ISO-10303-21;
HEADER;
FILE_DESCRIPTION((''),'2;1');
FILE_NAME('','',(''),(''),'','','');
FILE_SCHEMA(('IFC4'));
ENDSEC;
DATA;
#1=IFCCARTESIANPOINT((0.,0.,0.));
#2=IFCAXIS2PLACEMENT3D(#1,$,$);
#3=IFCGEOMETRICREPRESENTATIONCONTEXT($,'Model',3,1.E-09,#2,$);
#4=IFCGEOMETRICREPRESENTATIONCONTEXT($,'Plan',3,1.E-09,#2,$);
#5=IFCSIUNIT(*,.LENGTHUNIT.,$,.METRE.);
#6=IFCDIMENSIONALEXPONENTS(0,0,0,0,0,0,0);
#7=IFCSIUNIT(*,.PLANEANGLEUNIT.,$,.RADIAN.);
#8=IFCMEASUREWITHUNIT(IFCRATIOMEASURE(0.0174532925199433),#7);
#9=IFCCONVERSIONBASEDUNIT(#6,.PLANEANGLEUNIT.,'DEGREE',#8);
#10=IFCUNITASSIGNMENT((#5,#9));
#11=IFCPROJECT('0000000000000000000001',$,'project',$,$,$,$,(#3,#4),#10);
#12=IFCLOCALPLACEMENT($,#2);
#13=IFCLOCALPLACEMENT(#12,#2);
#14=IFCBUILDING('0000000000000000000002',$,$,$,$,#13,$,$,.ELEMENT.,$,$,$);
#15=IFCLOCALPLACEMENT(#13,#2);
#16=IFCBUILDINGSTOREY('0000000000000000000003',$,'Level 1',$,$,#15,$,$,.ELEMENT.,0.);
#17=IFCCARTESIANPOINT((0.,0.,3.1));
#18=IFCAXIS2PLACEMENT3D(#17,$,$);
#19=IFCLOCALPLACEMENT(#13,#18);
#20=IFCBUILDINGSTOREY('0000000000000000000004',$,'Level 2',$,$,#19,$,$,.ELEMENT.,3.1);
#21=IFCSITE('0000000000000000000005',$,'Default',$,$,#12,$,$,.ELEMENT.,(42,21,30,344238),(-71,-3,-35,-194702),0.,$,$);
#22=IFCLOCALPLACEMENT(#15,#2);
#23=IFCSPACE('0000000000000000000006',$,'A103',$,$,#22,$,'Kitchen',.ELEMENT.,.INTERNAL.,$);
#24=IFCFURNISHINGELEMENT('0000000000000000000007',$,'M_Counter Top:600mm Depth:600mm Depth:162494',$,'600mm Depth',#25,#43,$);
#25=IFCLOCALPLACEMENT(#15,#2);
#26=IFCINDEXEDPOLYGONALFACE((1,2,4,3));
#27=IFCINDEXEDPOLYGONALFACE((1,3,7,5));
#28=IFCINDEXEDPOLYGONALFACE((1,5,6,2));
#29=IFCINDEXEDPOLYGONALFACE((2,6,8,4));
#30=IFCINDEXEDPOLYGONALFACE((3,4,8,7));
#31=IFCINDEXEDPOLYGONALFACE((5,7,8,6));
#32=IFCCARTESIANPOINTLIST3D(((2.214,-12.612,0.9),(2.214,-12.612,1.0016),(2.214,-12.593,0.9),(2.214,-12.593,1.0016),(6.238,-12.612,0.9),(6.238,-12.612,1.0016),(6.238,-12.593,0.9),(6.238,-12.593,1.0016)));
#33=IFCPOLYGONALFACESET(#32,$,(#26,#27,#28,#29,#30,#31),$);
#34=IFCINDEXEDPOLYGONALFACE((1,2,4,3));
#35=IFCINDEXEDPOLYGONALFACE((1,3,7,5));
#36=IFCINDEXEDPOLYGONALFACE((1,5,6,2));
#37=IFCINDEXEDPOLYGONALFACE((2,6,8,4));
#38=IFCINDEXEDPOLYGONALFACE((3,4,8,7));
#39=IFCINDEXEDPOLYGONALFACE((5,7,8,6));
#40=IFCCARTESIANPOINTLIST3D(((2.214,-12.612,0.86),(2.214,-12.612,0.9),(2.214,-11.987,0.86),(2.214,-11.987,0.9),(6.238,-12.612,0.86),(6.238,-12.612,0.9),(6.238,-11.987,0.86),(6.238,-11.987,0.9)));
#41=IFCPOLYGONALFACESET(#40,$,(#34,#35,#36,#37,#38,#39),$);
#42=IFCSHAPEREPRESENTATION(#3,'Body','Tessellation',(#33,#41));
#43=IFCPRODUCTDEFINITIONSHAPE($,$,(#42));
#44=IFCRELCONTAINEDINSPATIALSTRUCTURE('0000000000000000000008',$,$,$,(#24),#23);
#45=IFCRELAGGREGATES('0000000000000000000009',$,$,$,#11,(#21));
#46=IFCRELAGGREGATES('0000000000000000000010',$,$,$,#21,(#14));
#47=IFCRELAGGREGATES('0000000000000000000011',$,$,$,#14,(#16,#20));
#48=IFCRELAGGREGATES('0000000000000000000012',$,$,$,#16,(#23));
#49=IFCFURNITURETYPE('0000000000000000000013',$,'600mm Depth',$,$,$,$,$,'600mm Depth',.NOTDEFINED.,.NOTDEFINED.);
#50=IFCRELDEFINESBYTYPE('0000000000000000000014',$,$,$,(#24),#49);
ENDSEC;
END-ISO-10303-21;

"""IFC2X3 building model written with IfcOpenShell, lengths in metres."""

from ifc_helpers import new_model, entity, si_unit, converted_unit, frame, origin, origin_2d_with_axis, place, context, project, spatial, rectangle, extrude, source, transform, mapped, type_object, type_shapes, element, save


model = new_model("IFC2X3")

# Units and contexts
model_context = context("Model", 3, precision=1e-09, world=origin())
plan_context = context("Plan", 3, precision=1e-09, world=origin())
ifc_project = project(units=[si_unit("LENGTHUNIT", "METRE"), converted_unit("PLANEANGLEUNIT", "DEGREE", entity("IfcRatioMeasure", 0.0174532925199433), si_unit("PLANEANGLEUNIT", "RADIAN"), dimensions=[0, 0, 0, 0, 0, 0, 0])], contexts=[model_context, plan_context])

# Site, building, storey
site_placement = place(None, origin())
site = spatial("IfcSite", under=ifc_project, at=site_placement, Name="Default", CompositionType="ELEMENT", RefLatitude=(42, 21, 30, 344238), RefLongitude=(-71, -3, -35, -194702), RefElevation=0.0)
building_placement = place(site_placement, origin())
building = spatial("IfcBuilding", under=site, at=building_placement, CompositionType="ELEMENT")
storey_1_placement = place(building_placement, origin())
storey_1 = spatial("IfcBuildingStorey", under=building, at=storey_1_placement, Name="Level 1", CompositionType="ELEMENT", Elevation=0.0)

# Shared definitions
storey_2_placement = place(building_placement, frame((0.0, 0.0, 3.1)))
storey_2 = spatial("IfcBuildingStorey", under=building, at=storey_2_placement, Name="Level 2", CompositionType="ELEMENT", Elevation=3.1)

# Shared definitions
placement_1 = place(storey_1_placement, origin())
space_1 = spatial("IfcSpace", under=storey_1, at=placement_1, Name="A103", LongName="Kitchen", CompositionType="ELEMENT", InteriorOrExteriorSpace="INTERNAL")

# Furnishing element
furniture_type_1 = type_object("IfcFurnitureType", Name="600mm Depth", ElementType="600mm Depth", AssemblyPlace="NOTDEFINED")
shared_shape_1 = source(origin(), model_context, "Body", "SweptSolid", [
    extrude(rectangle(XDim=0.0191, YDim=4.024, at=origin_2d_with_axis()), frame((0.8115, -0.0095, 0.9), z_axis=(0.0, 0.0, 1.0), x_axis=(0.0, -1.0, 0.0)), (0.0, 0.0, 1.0), 0.1016),
    extrude(rectangle(XDim=4.024, YDim=0.625, at=origin_2d_with_axis()), frame((0.8115, -0.3125, 0.86), z_axis=(0.0, 0.0, 1.0), x_axis=(-1.0, 0.0, 0.0)), (0.0, 0.0, 1.0), 0.04),
])
type_shapes(furniture_type_1, [shared_shape_1])
furnishing_1_placement = place(placement_1, frame((5.0375, -12.612, 0.0), z_axis=(0.0, 0.0, 1.0), x_axis=(-1.0, 0.0, 0.0)))
element("IfcFurnishingElement", 1, at=furnishing_1_placement, inside=space_1, type_object=furniture_type_1, Name="M_Counter Top:600mm Depth:600mm Depth:162494", ObjectType="600mm Depth", context=model_context, shape_type="MappedRepresentation", body=[
    mapped(shared_shape_1, transform((0.0, 0.0, 0.0), scale=1.0)),
])

save(model, "model.ifc")
